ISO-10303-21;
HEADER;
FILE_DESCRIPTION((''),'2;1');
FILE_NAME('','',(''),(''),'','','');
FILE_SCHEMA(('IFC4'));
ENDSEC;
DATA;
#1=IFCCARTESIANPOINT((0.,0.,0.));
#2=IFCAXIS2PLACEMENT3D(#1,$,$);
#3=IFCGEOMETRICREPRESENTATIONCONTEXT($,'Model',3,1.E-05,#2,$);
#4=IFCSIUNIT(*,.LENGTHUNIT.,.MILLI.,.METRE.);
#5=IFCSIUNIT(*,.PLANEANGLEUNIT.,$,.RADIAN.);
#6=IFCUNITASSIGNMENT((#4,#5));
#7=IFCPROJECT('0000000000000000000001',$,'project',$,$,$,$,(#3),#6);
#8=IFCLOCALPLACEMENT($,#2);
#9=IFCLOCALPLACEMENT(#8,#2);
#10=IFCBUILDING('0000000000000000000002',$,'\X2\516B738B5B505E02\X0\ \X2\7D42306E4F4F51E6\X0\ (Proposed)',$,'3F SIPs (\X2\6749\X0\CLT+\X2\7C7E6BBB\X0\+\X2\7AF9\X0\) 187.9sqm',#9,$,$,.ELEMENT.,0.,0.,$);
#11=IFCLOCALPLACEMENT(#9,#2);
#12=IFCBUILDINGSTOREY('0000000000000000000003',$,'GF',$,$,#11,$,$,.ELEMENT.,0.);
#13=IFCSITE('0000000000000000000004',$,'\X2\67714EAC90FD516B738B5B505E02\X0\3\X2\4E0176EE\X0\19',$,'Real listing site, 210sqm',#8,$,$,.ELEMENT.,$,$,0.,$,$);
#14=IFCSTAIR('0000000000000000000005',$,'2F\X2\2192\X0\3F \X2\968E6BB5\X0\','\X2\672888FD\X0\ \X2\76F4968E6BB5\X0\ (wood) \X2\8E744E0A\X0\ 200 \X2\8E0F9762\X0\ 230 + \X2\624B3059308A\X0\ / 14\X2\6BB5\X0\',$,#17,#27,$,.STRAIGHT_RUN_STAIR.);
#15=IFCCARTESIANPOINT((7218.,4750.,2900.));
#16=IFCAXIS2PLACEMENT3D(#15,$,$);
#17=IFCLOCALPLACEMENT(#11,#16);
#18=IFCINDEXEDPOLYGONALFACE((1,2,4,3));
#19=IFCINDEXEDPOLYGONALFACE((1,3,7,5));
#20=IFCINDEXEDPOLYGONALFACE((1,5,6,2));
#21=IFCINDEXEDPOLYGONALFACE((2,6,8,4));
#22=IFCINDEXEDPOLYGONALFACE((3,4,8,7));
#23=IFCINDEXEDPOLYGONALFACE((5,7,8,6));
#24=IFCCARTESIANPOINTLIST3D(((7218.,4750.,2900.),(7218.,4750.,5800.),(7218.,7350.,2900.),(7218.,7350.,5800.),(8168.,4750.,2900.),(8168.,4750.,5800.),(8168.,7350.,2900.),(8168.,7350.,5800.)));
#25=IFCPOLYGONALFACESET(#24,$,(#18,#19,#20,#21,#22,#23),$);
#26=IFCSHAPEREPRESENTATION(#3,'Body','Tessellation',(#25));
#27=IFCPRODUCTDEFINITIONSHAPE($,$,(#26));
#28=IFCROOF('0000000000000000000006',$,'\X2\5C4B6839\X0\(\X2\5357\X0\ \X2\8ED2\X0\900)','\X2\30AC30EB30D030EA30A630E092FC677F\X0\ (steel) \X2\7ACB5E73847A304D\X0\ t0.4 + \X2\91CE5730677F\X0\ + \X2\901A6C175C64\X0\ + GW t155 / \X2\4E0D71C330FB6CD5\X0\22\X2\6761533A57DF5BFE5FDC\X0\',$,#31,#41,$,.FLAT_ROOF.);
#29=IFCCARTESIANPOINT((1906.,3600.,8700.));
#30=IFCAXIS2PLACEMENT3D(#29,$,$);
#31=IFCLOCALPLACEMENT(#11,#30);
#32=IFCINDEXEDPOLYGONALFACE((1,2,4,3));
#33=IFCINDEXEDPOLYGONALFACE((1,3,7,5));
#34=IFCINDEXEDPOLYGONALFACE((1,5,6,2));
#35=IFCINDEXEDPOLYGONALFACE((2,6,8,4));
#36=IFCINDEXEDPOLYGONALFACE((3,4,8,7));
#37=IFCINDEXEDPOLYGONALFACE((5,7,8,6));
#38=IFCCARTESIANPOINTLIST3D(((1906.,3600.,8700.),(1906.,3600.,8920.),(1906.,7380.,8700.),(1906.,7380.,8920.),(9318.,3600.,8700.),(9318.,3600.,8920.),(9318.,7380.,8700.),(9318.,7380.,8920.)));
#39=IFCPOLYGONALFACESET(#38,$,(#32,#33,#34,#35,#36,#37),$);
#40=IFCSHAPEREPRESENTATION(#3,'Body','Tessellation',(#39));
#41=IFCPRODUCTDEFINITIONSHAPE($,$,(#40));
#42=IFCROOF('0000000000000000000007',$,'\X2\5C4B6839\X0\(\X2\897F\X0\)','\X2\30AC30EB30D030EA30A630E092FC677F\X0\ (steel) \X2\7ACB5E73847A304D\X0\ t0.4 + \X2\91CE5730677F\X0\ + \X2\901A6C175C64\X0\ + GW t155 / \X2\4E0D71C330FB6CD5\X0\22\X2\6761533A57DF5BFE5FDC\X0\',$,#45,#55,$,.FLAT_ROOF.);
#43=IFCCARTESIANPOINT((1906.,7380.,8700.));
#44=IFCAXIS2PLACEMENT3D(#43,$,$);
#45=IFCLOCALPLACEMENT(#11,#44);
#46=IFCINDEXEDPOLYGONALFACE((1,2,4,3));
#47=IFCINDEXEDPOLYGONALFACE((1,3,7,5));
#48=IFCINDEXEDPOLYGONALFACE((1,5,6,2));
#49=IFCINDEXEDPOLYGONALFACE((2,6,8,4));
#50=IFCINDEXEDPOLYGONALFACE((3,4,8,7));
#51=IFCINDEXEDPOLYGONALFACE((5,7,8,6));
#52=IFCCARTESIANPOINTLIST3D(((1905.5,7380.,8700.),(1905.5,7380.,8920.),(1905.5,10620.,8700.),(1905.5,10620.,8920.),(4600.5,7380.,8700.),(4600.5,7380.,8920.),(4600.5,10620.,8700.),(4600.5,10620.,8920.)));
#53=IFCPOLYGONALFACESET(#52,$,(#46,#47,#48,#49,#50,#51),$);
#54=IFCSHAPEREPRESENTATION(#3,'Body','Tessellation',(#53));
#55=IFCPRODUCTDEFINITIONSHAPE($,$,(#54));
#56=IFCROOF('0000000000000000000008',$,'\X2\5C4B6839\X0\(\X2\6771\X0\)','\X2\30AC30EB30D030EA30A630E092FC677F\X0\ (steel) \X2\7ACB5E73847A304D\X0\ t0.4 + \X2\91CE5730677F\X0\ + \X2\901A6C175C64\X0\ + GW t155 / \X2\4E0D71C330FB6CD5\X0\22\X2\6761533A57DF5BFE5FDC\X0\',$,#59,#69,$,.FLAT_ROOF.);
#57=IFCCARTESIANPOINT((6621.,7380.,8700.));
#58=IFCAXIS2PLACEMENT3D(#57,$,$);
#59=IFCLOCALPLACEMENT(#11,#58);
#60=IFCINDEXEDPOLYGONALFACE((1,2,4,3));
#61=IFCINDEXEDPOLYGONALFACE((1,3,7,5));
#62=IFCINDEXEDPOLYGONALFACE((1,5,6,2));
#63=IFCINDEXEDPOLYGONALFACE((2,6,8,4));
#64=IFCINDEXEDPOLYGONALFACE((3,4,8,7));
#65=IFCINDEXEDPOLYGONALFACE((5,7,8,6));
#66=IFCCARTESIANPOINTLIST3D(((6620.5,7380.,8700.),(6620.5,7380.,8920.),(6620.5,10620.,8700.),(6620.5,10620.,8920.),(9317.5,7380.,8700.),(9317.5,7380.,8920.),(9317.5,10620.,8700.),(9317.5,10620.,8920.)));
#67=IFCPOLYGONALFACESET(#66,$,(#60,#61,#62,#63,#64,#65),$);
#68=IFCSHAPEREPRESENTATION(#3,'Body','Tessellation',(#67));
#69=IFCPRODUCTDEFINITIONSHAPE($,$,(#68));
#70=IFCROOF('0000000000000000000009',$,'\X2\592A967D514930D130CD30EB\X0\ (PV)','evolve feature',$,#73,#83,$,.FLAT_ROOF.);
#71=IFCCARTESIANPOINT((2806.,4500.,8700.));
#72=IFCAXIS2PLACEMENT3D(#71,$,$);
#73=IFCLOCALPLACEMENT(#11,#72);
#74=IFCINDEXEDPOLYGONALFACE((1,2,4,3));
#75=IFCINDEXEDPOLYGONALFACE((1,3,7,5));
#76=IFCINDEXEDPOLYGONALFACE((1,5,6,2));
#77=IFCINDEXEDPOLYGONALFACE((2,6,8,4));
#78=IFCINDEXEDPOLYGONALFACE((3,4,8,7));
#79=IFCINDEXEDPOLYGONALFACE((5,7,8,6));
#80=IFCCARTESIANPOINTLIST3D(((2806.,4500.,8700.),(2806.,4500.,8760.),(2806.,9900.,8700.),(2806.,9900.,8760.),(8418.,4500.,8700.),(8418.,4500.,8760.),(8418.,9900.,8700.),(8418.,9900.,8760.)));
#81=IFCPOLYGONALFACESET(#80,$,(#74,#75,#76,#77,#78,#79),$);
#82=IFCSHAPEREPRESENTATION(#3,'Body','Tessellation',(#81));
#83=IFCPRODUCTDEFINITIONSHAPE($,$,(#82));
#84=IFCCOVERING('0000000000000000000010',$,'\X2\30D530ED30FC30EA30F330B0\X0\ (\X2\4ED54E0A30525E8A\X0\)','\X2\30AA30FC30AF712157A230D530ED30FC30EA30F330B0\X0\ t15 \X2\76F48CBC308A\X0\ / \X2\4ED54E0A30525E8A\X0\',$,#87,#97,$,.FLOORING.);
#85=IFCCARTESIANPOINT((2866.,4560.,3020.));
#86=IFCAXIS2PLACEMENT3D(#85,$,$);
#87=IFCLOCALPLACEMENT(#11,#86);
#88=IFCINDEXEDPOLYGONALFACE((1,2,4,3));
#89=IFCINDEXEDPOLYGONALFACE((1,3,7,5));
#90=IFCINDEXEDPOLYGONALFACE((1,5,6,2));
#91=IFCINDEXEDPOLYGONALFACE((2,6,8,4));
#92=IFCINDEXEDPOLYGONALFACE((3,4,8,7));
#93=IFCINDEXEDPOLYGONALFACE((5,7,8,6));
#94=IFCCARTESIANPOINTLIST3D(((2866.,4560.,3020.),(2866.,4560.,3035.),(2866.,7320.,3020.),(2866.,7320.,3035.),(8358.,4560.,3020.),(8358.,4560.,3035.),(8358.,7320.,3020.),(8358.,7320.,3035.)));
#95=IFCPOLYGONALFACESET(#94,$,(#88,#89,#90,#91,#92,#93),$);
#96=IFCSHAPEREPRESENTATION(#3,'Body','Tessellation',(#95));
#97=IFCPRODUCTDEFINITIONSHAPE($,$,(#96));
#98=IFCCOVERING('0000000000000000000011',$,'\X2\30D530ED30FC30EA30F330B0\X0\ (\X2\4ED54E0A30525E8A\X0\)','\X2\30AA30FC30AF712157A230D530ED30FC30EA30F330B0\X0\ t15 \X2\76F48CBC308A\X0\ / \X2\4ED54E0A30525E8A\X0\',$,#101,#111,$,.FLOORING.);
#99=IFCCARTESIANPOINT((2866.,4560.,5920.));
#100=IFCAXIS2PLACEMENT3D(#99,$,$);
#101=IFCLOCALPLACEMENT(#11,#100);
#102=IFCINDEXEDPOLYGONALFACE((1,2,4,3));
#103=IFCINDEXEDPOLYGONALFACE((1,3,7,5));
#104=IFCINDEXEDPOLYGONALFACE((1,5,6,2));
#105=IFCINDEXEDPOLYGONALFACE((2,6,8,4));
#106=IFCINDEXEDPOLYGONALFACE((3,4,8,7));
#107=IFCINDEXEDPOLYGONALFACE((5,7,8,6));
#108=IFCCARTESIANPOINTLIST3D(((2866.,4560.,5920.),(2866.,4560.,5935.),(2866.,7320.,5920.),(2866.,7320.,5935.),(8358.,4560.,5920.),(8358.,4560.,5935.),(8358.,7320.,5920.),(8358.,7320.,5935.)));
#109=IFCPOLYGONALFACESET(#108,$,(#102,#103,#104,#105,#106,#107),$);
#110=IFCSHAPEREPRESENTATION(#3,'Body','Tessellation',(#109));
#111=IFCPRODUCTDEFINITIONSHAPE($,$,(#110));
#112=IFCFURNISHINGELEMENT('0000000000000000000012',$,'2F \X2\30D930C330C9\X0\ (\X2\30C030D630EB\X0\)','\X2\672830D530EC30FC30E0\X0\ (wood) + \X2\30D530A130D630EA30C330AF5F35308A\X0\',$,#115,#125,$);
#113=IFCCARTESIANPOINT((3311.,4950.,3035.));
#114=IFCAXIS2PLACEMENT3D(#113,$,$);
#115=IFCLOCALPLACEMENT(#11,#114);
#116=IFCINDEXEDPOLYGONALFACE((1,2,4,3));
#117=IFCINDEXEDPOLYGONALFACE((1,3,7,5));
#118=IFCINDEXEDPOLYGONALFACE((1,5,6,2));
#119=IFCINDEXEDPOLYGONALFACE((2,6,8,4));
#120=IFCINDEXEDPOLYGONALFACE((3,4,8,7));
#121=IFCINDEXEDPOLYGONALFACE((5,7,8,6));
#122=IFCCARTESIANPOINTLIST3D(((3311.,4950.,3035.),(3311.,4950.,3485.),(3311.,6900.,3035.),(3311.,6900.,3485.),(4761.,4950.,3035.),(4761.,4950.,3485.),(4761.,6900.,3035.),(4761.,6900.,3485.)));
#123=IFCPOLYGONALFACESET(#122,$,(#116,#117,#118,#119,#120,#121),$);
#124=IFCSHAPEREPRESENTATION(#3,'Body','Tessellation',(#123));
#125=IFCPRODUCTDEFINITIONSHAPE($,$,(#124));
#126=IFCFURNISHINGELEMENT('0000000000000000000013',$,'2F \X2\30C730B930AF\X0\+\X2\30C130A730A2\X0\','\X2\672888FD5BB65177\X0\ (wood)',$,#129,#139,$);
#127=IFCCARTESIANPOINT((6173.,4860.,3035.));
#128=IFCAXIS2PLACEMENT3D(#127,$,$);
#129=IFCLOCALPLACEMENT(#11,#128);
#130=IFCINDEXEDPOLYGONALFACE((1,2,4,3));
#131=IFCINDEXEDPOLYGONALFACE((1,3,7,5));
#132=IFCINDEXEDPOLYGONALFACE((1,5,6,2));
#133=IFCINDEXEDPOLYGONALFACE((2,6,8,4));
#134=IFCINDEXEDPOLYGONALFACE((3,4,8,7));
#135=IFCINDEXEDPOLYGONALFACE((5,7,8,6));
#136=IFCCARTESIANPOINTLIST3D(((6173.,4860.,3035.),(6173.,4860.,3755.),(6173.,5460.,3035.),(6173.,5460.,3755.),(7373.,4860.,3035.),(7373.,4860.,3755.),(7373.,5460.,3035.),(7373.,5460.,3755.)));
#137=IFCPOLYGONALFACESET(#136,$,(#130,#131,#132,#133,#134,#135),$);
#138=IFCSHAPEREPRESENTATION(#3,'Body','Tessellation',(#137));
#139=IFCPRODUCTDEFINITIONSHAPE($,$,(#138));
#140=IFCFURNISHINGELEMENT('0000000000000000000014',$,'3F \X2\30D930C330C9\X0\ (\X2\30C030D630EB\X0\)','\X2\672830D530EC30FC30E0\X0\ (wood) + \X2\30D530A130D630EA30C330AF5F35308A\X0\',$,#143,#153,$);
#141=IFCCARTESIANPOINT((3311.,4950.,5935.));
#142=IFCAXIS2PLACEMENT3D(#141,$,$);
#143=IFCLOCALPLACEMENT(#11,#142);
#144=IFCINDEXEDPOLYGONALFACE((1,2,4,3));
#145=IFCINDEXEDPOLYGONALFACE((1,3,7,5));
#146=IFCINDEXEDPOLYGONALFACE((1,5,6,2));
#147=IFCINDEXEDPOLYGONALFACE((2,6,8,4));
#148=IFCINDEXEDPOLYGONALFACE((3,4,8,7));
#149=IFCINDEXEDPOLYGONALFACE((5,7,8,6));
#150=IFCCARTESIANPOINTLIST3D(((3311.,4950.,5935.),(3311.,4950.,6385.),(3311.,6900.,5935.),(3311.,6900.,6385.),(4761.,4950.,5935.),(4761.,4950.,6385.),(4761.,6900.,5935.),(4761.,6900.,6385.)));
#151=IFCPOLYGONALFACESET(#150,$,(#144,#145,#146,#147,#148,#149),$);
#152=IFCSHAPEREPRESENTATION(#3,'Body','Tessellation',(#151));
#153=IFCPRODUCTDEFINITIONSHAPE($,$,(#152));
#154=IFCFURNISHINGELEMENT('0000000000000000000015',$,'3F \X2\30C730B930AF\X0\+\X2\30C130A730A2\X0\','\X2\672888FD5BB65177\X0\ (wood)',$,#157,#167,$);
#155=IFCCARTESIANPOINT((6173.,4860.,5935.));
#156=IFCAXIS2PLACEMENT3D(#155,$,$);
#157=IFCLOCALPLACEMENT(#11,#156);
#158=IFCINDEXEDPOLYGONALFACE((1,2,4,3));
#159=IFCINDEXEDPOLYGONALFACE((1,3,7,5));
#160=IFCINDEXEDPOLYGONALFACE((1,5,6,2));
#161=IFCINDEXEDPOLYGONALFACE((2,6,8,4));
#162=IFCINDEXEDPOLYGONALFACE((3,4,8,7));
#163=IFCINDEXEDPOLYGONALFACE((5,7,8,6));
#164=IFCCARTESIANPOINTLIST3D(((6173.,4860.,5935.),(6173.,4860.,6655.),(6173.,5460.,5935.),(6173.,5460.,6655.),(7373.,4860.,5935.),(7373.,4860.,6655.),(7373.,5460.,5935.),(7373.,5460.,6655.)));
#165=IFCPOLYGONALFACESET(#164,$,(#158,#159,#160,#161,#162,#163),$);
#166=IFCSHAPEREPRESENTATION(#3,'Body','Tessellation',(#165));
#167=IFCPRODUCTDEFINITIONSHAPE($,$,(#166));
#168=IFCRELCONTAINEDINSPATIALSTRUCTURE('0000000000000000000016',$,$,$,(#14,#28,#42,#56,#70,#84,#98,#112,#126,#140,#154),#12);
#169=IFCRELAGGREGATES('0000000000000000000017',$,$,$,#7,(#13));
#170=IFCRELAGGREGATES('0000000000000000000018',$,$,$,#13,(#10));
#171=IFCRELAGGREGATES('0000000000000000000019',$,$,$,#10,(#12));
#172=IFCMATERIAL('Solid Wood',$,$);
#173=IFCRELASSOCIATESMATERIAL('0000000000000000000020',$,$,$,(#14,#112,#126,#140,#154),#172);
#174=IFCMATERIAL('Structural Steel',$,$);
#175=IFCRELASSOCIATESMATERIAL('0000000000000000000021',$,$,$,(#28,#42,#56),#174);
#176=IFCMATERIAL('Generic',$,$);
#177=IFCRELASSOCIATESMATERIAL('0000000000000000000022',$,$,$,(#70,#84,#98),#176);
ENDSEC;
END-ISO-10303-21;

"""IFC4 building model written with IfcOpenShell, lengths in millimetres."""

from ifc_helpers import new_model, si_unit, frame, frame_2d, origin, place, context, project, spatial, rectangle, extrude, material, element, save


model = new_model("IFC4")

# Units and contexts
model_context = context("Model", 3, precision=1e-05, world=origin())
ifc_project = project(units=[si_unit("LENGTHUNIT", "METRE", prefix="MILLI"), si_unit("PLANEANGLEUNIT", "RADIAN")], contexts=[model_context])

# Site, building, storey
site_placement = place(None, origin())
site = spatial("IfcSite", under=ifc_project, at=site_placement, Name="東京都八王子市3丁目19", ObjectType="Real listing site, 210sqm", CompositionType="ELEMENT", RefElevation=0.0)
building_placement = place(site_placement, origin())
building = spatial("IfcBuilding", under=site, at=building_placement, Name="八王子市 終の住処 (Proposed)", ObjectType="3F SIPs (杉CLT+籾殻+竹) 187.9sqm", CompositionType="ELEMENT", ElevationOfRefHeight=0.0, ElevationOfTerrain=0.0)
storey_placement = place(building_placement, origin())
storey = spatial("IfcBuildingStorey", under=building, at=storey_placement, Name="GF", CompositionType="ELEMENT", Elevation=0.0)

# Shared definitions
ifc_material_1 = material(Name="Solid Wood")

# Stair
stair_placement = place(storey_placement, frame((7218.0, 4750.0, 2900.0)))
element("IfcStair", 1, at=stair_placement, inside=storey, material=ifc_material_1, Name="2F→3F 階段", Description="木製 直階段 (wood) 蹴上 200 踏面 230 + 手すり / 14段", PredefinedType="STRAIGHT_RUN_STAIR", context=model_context, shape_type="SweptSolid", body=[
    extrude(rectangle(XDim=950.0, YDim=2600.0, at=frame_2d((475.0, 1300.0))), frame((7218.0, 4750.0, 2900.0)), (0.0, 0.0, 1.0), 2900.0),
])

# Roofs
ifc_material_2 = material(Name="Structural Steel")
roof_1_placement = place(storey_placement, frame((1906.0, 3600.0, 8700.0)))
element("IfcRoof", 2, at=roof_1_placement, inside=storey, material=ifc_material_2, Name="屋根(南 軒900)", Description="ガルバリウム鋼板 (steel) 立平葺き t0.4 + 野地板 + 通気層 + GW t155 / 不燃・法22条区域対応", PredefinedType="FLAT_ROOF", context=model_context, shape_type="SweptSolid", body=[
    extrude(rectangle(XDim=7412.0, YDim=3780.0, at=frame_2d((3706.0, 1890.0))), frame((1906.0, 3600.0, 8700.0)), (0.0, 0.0, 1.0), 220.0),
])
roof_2_placement = place(storey_placement, frame((1906.0, 7380.0, 8700.0)))
element("IfcRoof", 3, at=roof_2_placement, inside=storey, material=ifc_material_2, Name="屋根(西)", Description="ガルバリウム鋼板 (steel) 立平葺き t0.4 + 野地板 + 通気層 + GW t155 / 不燃・法22条区域対応", PredefinedType="FLAT_ROOF", context=model_context, shape_type="SweptSolid", body=[
    extrude(rectangle(XDim=2695.0, YDim=3240.0, at=frame_2d((1347.0, 1620.0))), frame((1906.0, 7380.0, 8700.0)), (0.0, 0.0, 1.0), 220.0),
])
roof_3_placement = place(storey_placement, frame((6621.0, 7380.0, 8700.0)))
element("IfcRoof", 4, at=roof_3_placement, inside=storey, material=ifc_material_2, Name="屋根(東)", Description="ガルバリウム鋼板 (steel) 立平葺き t0.4 + 野地板 + 通気層 + GW t155 / 不燃・法22条区域対応", PredefinedType="FLAT_ROOF", context=model_context, shape_type="SweptSolid", body=[
    extrude(rectangle(XDim=2697.0, YDim=3240.0, at=frame_2d((1348.0, 1620.0))), frame((6621.0, 7380.0, 8700.0)), (0.0, 0.0, 1.0), 220.0),
])
ifc_material_3 = material(Name="Generic")
roof_4_placement = place(storey_placement, frame((2806.0, 4500.0, 8700.0)))
element("IfcRoof", 5, at=roof_4_placement, inside=storey, material=ifc_material_3, Name="太陽光パネル (PV)", Description="evolve feature", PredefinedType="FLAT_ROOF", context=model_context, shape_type="SweptSolid", body=[
    extrude(rectangle(XDim=5612.0, YDim=5400.0, at=frame_2d((2806.0, 2700.0))), frame((2806.0, 4500.0, 8700.0)), (0.0, 0.0, 1.0), 60.0),
])

# Coverings
covering_1_placement = place(storey_placement, frame((2866.0, 4560.0, 3020.0)))
element("IfcCovering", 6, at=covering_1_placement, inside=storey, material=ifc_material_3, Name="フローリング (仕上げ床)", Description="オーク無垢フローリング t15 直貼り / 仕上げ床", PredefinedType="FLOORING", context=model_context, shape_type="SweptSolid", body=[
    extrude(rectangle(XDim=5492.0, YDim=2760.0, at=frame_2d((2746.0, 1380.0))), frame((2866.0, 4560.0, 3020.0)), (0.0, 0.0, 1.0), 15.0),
])
covering_2_placement = place(storey_placement, frame((2866.0, 4560.0, 5920.0)))
element("IfcCovering", 7, at=covering_2_placement, inside=storey, material=ifc_material_3, Name="フローリング (仕上げ床)", Description="オーク無垢フローリング t15 直貼り / 仕上げ床", PredefinedType="FLOORING", context=model_context, shape_type="SweptSolid", body=[
    extrude(rectangle(XDim=5492.0, YDim=2760.0, at=frame_2d((2746.0, 1380.0))), frame((2866.0, 4560.0, 5920.0)), (0.0, 0.0, 1.0), 15.0),
])

# Furnishing elements
furnishing_1_placement = place(storey_placement, frame((3311.0, 4950.0, 3035.0)))
element("IfcFurnishingElement", 8, at=furnishing_1_placement, inside=storey, material=ifc_material_1, Name="2F ベッド (ダブル)", Description="木フレーム (wood) + ファブリック張り", context=model_context, shape_type="SweptSolid", body=[
    extrude(rectangle(XDim=1450.0, YDim=1950.0, at=frame_2d((725.0, 975.0))), frame((3311.0, 4950.0, 3035.0)), (0.0, 0.0, 1.0), 450.0),
])
furnishing_2_placement = place(storey_placement, frame((6173.0, 4860.0, 3035.0)))
element("IfcFurnishingElement", 9, at=furnishing_2_placement, inside=storey, material=ifc_material_1, Name="2F デスク+チェア", Description="木製家具 (wood)", context=model_context, shape_type="SweptSolid", body=[
    extrude(rectangle(XDim=1200.0, YDim=600.0, at=frame_2d((600.0, 300.0))), frame((6173.0, 4860.0, 3035.0)), (0.0, 0.0, 1.0), 720.0),
])
furnishing_3_placement = place(storey_placement, frame((3311.0, 4950.0, 5935.0)))
element("IfcFurnishingElement", 10, at=furnishing_3_placement, inside=storey, material=ifc_material_1, Name="3F ベッド (ダブル)", Description="木フレーム (wood) + ファブリック張り", context=model_context, shape_type="SweptSolid", body=[
    extrude(rectangle(XDim=1450.0, YDim=1950.0, at=frame_2d((725.0, 975.0))), frame((3311.0, 4950.0, 5935.0)), (0.0, 0.0, 1.0), 450.0),
])
furnishing_4_placement = place(storey_placement, frame((6173.0, 4860.0, 5935.0)))
element("IfcFurnishingElement", 11, at=furnishing_4_placement, inside=storey, material=ifc_material_1, Name="3F デスク+チェア", Description="木製家具 (wood)", context=model_context, shape_type="SweptSolid", body=[
    extrude(rectangle(XDim=1200.0, YDim=600.0, at=frame_2d((600.0, 300.0))), frame((6173.0, 4860.0, 5935.0)), (0.0, 0.0, 1.0), 720.0),
])

save(model, "model.ifc")
